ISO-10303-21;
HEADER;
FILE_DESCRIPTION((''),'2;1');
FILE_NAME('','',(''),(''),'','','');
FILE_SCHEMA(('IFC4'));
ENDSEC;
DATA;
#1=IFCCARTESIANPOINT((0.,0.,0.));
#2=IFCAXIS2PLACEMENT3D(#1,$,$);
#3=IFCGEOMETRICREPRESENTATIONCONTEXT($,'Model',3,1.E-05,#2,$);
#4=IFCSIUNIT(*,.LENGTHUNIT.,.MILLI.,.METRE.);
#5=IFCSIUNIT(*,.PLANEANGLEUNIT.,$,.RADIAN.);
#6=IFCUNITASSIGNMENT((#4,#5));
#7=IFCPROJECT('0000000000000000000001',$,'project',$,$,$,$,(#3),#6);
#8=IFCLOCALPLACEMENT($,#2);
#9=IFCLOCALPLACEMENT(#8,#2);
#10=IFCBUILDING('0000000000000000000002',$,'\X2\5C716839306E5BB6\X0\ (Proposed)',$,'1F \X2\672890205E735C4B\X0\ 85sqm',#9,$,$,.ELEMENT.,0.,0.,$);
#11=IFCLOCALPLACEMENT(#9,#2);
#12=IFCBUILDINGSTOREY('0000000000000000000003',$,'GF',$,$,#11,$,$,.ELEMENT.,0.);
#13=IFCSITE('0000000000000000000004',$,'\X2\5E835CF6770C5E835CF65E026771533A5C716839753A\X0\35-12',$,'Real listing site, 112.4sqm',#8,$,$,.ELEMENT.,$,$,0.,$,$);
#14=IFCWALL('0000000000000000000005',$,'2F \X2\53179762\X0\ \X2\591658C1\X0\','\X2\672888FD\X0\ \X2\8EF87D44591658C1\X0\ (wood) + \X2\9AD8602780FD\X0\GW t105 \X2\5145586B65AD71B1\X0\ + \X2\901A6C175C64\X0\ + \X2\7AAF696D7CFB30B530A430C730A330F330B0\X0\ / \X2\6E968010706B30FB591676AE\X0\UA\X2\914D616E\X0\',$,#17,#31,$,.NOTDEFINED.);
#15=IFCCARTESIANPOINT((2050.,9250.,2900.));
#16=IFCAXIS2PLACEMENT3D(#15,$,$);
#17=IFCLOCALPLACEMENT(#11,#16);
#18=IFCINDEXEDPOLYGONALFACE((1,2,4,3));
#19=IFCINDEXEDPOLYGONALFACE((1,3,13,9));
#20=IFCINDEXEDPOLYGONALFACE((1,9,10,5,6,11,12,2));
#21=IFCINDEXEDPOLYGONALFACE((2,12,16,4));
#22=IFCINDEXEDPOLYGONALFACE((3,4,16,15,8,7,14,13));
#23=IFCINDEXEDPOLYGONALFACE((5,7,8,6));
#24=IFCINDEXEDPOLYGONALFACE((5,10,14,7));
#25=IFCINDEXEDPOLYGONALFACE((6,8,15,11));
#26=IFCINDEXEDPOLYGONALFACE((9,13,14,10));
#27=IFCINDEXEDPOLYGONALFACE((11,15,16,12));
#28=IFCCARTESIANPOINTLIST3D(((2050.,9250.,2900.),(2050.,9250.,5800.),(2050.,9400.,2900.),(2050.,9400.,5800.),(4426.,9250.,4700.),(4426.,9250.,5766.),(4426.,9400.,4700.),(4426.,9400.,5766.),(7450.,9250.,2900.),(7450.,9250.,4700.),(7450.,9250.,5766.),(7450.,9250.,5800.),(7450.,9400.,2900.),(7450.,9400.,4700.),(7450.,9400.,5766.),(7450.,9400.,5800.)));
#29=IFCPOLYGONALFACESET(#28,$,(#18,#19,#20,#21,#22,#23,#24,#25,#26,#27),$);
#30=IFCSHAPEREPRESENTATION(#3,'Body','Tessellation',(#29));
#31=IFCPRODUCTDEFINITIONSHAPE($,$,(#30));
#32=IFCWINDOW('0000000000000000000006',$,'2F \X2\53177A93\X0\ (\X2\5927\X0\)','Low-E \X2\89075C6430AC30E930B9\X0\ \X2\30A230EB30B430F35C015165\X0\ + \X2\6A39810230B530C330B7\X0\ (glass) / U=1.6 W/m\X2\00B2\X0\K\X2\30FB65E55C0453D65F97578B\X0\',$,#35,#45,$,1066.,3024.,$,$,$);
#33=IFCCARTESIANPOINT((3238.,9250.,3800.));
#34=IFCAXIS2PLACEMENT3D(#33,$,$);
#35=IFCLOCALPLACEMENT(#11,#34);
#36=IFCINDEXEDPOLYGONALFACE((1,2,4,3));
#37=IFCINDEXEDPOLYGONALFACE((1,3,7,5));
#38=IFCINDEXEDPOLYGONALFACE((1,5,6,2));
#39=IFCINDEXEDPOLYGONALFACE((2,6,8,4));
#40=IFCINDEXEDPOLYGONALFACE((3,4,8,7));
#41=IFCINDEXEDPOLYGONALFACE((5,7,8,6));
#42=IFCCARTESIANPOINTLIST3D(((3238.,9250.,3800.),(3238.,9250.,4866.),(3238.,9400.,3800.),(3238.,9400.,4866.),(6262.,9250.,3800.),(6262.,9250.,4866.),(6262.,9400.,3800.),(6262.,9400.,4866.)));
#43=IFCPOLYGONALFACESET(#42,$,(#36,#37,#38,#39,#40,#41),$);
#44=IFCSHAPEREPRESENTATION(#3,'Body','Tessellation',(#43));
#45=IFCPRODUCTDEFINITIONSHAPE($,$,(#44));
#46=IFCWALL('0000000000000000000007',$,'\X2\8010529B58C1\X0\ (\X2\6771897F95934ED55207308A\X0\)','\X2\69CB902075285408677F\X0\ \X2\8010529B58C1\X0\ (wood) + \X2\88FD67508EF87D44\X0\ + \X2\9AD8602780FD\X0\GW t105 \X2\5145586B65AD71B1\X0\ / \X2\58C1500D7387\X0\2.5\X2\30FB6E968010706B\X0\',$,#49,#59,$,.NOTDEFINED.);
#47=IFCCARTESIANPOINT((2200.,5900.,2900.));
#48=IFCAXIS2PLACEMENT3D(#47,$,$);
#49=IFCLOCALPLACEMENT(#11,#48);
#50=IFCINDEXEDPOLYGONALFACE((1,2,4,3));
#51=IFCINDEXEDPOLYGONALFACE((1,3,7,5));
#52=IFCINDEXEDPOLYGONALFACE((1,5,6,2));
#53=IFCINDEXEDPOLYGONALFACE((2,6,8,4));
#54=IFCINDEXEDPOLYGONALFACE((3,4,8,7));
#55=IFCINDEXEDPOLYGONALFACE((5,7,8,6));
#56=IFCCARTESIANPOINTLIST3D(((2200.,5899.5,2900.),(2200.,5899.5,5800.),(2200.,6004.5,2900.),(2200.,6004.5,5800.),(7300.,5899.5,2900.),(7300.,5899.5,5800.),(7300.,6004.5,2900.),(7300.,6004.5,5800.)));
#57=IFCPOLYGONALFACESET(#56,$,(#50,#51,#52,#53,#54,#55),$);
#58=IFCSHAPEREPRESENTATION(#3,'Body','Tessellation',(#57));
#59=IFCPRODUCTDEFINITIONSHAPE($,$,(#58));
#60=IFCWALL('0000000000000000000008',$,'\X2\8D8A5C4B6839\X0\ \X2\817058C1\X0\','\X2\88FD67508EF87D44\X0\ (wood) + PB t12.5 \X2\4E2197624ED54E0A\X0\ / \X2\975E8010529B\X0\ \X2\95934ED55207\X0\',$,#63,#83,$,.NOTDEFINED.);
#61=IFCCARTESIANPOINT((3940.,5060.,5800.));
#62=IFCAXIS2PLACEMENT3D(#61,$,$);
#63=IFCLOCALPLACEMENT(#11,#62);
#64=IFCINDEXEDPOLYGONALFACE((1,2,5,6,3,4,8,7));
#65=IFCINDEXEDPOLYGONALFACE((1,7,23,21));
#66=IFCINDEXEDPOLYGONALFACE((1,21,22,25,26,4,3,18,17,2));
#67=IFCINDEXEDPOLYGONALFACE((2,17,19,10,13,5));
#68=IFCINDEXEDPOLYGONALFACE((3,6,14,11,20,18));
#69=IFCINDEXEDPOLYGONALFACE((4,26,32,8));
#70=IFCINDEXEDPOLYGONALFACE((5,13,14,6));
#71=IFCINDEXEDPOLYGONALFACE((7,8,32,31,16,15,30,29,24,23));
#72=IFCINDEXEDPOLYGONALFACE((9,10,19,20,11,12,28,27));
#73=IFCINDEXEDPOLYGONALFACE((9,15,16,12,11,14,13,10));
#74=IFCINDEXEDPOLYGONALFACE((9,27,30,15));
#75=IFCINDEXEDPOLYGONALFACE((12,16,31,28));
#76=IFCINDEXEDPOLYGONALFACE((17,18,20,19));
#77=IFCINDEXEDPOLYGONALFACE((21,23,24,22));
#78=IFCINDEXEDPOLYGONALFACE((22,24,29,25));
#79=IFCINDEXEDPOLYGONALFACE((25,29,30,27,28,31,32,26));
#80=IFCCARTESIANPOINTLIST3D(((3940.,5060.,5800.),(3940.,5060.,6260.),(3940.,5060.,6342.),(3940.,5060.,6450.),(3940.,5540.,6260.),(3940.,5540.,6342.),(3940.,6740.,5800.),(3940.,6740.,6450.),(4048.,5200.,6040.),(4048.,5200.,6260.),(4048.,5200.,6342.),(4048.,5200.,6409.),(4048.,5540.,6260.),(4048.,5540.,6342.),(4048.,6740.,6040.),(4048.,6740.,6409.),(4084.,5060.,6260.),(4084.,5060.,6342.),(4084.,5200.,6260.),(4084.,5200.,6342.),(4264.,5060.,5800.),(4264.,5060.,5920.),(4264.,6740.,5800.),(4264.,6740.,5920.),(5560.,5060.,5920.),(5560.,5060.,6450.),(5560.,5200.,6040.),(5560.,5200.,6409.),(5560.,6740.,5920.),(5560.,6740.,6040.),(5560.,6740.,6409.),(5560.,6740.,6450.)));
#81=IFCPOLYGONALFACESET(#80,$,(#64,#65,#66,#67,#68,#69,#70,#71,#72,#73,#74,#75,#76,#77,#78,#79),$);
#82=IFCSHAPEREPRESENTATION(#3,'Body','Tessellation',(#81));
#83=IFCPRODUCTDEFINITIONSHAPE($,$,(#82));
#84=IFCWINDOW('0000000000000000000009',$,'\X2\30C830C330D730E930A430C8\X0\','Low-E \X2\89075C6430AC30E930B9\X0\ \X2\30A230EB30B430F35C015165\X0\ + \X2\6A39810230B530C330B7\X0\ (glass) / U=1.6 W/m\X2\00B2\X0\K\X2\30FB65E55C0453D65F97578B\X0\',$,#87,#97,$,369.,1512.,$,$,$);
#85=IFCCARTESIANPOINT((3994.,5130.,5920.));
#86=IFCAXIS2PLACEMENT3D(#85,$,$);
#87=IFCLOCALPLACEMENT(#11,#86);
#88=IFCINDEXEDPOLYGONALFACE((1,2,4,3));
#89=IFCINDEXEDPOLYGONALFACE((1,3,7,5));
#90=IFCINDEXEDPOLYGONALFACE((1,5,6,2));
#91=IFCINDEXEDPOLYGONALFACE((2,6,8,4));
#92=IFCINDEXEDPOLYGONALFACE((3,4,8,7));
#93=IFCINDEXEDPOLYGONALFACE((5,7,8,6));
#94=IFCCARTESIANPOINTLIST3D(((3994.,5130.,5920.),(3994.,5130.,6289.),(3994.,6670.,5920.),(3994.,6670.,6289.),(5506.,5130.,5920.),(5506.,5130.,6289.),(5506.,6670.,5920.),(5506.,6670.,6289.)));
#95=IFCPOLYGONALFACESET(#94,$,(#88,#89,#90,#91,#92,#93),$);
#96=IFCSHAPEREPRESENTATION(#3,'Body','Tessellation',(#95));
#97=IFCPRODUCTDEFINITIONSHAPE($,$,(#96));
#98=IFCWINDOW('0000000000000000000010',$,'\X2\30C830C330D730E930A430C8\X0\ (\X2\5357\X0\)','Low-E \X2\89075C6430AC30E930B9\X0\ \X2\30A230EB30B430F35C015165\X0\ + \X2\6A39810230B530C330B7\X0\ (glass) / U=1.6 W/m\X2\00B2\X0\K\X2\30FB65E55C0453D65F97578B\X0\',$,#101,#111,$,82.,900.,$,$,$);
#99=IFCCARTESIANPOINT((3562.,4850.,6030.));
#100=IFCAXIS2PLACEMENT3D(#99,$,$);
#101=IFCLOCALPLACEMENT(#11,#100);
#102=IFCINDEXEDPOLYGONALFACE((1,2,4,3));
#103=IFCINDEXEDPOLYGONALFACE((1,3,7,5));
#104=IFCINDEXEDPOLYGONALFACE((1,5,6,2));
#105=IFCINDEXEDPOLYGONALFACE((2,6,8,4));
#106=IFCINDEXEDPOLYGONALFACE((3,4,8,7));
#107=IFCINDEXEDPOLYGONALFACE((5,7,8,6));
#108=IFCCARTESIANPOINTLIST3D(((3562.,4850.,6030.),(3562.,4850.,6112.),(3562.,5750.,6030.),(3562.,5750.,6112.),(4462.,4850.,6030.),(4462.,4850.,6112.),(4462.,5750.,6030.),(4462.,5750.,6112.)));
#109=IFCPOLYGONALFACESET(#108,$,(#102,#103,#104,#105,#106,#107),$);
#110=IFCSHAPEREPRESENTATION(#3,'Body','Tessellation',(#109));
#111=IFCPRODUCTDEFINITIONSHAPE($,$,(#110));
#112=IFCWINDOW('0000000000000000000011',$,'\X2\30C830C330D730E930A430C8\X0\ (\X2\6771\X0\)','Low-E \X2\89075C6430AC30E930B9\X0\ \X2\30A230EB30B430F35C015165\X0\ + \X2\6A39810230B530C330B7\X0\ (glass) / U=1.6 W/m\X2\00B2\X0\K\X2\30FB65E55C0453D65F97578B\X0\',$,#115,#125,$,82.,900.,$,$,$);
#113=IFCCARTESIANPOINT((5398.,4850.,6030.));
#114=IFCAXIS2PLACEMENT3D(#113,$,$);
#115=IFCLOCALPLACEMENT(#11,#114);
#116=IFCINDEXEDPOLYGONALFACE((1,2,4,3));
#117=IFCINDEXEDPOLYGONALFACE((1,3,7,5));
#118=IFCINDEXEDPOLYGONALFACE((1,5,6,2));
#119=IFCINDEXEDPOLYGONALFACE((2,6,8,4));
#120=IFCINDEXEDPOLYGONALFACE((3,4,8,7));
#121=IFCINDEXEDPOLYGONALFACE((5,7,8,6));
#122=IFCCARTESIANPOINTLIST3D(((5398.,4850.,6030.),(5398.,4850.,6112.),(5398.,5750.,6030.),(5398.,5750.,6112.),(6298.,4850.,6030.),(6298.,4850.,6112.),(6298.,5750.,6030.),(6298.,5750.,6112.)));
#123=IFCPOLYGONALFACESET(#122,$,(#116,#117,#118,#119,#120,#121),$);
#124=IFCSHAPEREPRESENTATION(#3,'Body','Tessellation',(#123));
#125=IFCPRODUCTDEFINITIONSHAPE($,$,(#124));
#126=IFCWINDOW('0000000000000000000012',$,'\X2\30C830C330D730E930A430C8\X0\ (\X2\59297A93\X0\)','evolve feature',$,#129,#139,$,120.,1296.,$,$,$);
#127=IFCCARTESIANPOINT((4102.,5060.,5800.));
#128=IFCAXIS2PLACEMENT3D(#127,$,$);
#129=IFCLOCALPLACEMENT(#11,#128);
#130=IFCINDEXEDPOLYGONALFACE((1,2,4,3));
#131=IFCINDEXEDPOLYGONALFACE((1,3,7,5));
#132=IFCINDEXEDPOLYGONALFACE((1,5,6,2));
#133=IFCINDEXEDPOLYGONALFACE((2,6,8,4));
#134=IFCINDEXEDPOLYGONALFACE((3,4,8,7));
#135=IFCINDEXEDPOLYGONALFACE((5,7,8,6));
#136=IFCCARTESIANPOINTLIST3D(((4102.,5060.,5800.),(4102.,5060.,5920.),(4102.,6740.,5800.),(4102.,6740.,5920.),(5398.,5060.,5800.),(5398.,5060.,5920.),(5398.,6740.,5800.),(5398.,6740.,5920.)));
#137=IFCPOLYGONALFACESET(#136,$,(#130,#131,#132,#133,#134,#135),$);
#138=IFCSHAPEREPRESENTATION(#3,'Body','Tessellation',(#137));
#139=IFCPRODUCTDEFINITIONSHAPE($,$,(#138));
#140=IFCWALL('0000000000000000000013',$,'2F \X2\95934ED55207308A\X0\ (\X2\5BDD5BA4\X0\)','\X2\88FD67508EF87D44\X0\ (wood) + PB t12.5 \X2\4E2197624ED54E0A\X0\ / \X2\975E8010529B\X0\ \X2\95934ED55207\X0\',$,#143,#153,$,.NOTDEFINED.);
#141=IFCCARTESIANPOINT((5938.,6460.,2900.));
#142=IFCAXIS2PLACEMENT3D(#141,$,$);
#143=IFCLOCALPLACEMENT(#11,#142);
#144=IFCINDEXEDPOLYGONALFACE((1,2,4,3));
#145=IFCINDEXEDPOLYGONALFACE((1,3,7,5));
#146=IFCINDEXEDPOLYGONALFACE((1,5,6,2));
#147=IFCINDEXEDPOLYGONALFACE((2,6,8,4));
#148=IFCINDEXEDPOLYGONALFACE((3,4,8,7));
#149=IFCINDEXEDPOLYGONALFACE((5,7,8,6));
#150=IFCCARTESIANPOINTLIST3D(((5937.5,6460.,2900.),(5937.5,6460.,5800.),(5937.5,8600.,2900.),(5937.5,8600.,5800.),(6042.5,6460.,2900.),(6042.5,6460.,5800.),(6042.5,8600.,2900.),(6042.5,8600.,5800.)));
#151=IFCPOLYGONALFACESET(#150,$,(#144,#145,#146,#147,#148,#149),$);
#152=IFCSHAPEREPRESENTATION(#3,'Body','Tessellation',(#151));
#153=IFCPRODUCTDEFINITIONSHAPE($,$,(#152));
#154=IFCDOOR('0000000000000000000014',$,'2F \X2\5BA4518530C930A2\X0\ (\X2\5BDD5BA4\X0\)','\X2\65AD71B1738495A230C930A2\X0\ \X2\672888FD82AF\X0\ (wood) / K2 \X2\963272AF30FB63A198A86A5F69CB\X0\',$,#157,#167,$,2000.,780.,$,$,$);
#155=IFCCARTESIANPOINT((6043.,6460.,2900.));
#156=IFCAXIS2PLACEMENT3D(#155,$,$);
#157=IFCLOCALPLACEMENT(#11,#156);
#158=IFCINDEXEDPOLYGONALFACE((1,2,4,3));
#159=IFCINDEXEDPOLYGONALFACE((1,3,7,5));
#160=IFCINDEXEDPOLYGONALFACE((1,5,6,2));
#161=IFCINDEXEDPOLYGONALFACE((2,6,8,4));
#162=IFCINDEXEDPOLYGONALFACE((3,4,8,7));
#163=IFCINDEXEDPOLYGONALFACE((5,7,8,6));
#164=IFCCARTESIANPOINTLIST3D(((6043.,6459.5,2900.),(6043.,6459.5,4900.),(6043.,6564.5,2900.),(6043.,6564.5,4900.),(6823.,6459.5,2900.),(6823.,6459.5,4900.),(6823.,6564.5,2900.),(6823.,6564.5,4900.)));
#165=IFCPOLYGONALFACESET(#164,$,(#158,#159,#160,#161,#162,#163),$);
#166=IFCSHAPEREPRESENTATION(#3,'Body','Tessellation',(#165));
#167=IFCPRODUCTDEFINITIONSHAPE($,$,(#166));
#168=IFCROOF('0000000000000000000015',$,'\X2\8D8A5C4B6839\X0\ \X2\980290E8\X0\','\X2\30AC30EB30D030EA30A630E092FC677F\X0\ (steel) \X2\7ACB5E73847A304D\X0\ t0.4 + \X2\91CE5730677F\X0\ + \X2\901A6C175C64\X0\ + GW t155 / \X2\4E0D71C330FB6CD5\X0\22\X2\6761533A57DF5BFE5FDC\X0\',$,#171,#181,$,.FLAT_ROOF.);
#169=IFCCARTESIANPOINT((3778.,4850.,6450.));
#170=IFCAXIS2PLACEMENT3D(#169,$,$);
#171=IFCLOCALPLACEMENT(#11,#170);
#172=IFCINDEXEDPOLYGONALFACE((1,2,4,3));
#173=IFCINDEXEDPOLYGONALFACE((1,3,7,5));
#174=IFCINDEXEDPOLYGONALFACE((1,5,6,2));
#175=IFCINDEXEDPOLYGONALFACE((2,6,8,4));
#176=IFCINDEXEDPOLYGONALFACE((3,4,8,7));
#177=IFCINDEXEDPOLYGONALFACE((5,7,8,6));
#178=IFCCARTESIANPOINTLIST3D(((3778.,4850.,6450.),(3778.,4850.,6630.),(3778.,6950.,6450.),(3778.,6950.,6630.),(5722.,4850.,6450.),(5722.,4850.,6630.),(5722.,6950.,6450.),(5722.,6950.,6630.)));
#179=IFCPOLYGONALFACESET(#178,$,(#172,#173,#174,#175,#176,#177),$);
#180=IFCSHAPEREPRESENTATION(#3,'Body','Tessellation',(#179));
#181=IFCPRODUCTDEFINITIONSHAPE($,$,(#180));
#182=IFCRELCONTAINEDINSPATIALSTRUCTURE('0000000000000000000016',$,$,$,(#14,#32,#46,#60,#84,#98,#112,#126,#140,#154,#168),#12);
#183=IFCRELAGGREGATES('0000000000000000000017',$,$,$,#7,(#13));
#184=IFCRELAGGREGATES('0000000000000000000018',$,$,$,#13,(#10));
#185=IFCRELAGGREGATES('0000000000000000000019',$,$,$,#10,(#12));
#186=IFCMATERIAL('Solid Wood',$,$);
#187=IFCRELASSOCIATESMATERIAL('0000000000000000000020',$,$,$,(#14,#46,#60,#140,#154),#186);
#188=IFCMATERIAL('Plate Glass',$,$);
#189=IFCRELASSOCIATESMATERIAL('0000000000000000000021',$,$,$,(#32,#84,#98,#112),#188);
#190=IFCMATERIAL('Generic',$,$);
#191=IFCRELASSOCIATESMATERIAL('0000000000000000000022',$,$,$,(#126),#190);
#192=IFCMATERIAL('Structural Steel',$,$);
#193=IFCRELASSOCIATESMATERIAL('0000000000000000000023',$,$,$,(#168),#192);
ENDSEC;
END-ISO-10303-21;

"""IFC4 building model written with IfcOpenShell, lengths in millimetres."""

from ifc_helpers import new_model, si_unit, frame, frame_2d, origin, place, context, project, spatial, rectangle, extrude, material, element, fill, save


model = new_model("IFC4")

# Units and contexts
model_context = context("Model", 3, precision=1e-05, world=origin())
ifc_project = project(units=[si_unit("LENGTHUNIT", "METRE", prefix="MILLI"), si_unit("PLANEANGLEUNIT", "RADIAN")], contexts=[model_context])

# Site, building, storey
site_placement = place(None, origin())
site = spatial("IfcSite", under=ifc_project, at=site_placement, Name="広島県広島市東区山根町35-12", ObjectType="Real listing site, 112.4sqm", CompositionType="ELEMENT", RefElevation=0.0)
building_placement = place(site_placement, origin())
building = spatial("IfcBuilding", under=site, at=building_placement, Name="山根の家 (Proposed)", ObjectType="1F 木造平屋 85sqm", CompositionType="ELEMENT", ElevationOfRefHeight=0.0, ElevationOfTerrain=0.0)
storey_placement = place(building_placement, origin())
storey = spatial("IfcBuildingStorey", under=building, at=storey_placement, Name="GF", CompositionType="ELEMENT", Elevation=0.0)

# Wall, opening, window
ifc_material_1 = material(Name="Solid Wood")
wall_1_placement = place(storey_placement, frame((2050.0, 9250.0, 2900.0)))
wall_1 = element("IfcWall", 1, at=wall_1_placement, inside=storey, material=ifc_material_1, Name="2F 北面 外壁", Description="木製 軸組外壁 (wood) + 高性能GW t105 充填断熱 + 通気層 + 窯業系サイディング / 準耐火・外皮UA配慮", PredefinedType="NOTDEFINED", context=model_context, shape_type="SweptSolid", body=[
    extrude(rectangle(XDim=5400.0, YDim=150.0, at=frame_2d((2700.0, 75.0))), frame((2050.0, 9250.0, 2900.0)), (0.0, 0.0, 1.0), 2900.0),
])
opening_1_placement = place(storey_placement, frame((3238.0, 9250.0, 3800.0)))
opening_1 = element("IfcOpeningElement", 2, at=opening_1_placement, cuts=wall_1, PredefinedType="NOTDEFINED", context=model_context, shape_type="SweptSolid", body=[
    extrude(rectangle(XDim=3024.0, YDim=150.0, at=frame_2d((1512.0, 75.0))), frame((3238.0, 9250.0, 3800.0)), (0.0, 0.0, 1.0), 1066.0),
])
ifc_material_2 = material(Name="Plate Glass")
window_1_placement = place(storey_placement, frame((3238.0, 9250.0, 3800.0)))
window_1 = element("IfcWindow", 3, at=window_1_placement, inside=storey, material=ifc_material_2, Name="2F 北窓 (大)", Description="Low-E 複層ガラス アルゴン封入 + 樹脂サッシ (glass) / U=1.6 W/m²K・日射取得型", OverallHeight=1066.0, OverallWidth=3024.0, context=model_context, shape_type="SweptSolid", body=[
    extrude(rectangle(XDim=3024.0, YDim=150.0, at=frame_2d((1512.0, 75.0))), frame((3238.0, 9250.0, 3800.0)), (0.0, 0.0, 1.0), 1066.0),
])
fill(opening_1, window_1)

# Wall
wall_2_placement = place(storey_placement, frame((2200.0, 5900.0, 2900.0)))
element("IfcWall", 4, at=wall_2_placement, inside=storey, material=ifc_material_1, Name="耐力壁 (東西間仕切り)", Description="構造用合板 耐力壁 (wood) + 製材軸組 + 高性能GW t105 充填断熱 / 壁倍率2.5・準耐火", PredefinedType="NOTDEFINED", context=model_context, shape_type="SweptSolid", body=[
    extrude(rectangle(XDim=5100.0, YDim=105.0, at=frame_2d((2550.0, 52.0))), frame((2200.0, 5900.0, 2900.0)), (0.0, 0.0, 1.0), 2900.0),
])

# Wall, openings, windows
wall_3_placement = place(storey_placement, frame((3940.0, 5060.0, 5800.0)))
wall_3 = element("IfcWall", 5, at=wall_3_placement, inside=storey, material=ifc_material_1, Name="越屋根 腰壁", Description="製材軸組 (wood) + PB t12.5 両面仕上 / 非耐力 間仕切", PredefinedType="NOTDEFINED", context=model_context, shape_type="SweptSolid", body=[
    extrude(rectangle(XDim=1620.0, YDim=1680.0, at=frame_2d((810.0, 840.0))), frame((3940.0, 5060.0, 5800.0)), (0.0, 0.0, 1.0), 650.0),
])
opening_2_placement = place(storey_placement, frame((3994.0, 5130.0, 5920.0)))
opening_2 = element("IfcOpeningElement", 6, at=opening_2_placement, cuts=wall_3, PredefinedType="NOTDEFINED", context=model_context, shape_type="SweptSolid", body=[
    extrude(rectangle(XDim=1512.0, YDim=1540.0, at=frame_2d((756.0, 770.0))), frame((3994.0, 5130.0, 5920.0)), (0.0, 0.0, 1.0), 369.0),
])
opening_3_placement = place(storey_placement, frame((3562.0, 4850.0, 6030.0)))
opening_3 = element("IfcOpeningElement", 7, at=opening_3_placement, cuts=wall_3, PredefinedType="NOTDEFINED", context=model_context, shape_type="SweptSolid", body=[
    extrude(rectangle(XDim=900.0, YDim=900.0, at=frame_2d((450.0, 450.0))), frame((3562.0, 4850.0, 6030.0)), (0.0, 0.0, 1.0), 82.0),
])
opening_4_placement = place(storey_placement, frame((5398.0, 4850.0, 6030.0)))
opening_4 = element("IfcOpeningElement", 8, at=opening_4_placement, cuts=wall_3, PredefinedType="NOTDEFINED", context=model_context, shape_type="SweptSolid", body=[
    extrude(rectangle(XDim=900.0, YDim=900.0, at=frame_2d((450.0, 450.0))), frame((5398.0, 4850.0, 6030.0)), (0.0, 0.0, 1.0), 82.0),
])
opening_5_placement = place(storey_placement, frame((4102.0, 5060.0, 5800.0)))
opening_5 = element("IfcOpeningElement", 9, at=opening_5_placement, cuts=wall_3, PredefinedType="NOTDEFINED", context=model_context, shape_type="SweptSolid", body=[
    extrude(rectangle(XDim=1296.0, YDim=1680.0, at=frame_2d((648.0, 840.0))), frame((4102.0, 5060.0, 5800.0)), (0.0, 0.0, 1.0), 120.0),
])
window_2_placement = place(storey_placement, frame((3994.0, 5130.0, 5920.0)))
window_2 = element("IfcWindow", 10, at=window_2_placement, inside=storey, material=ifc_material_2, Name="トップライト", Description="Low-E 複層ガラス アルゴン封入 + 樹脂サッシ (glass) / U=1.6 W/m²K・日射取得型", OverallHeight=369.0, OverallWidth=1512.0, context=model_context, shape_type="SweptSolid", body=[
    extrude(rectangle(XDim=1512.0, YDim=1540.0, at=frame_2d((756.0, 770.0))), frame((3994.0, 5130.0, 5920.0)), (0.0, 0.0, 1.0), 369.0),
])
fill(opening_2, window_2)
window_3_placement = place(storey_placement, frame((3562.0, 4850.0, 6030.0)))
window_3 = element("IfcWindow", 11, at=window_3_placement, inside=storey, material=ifc_material_2, Name="トップライト (南)", Description="Low-E 複層ガラス アルゴン封入 + 樹脂サッシ (glass) / U=1.6 W/m²K・日射取得型", OverallHeight=82.0, OverallWidth=900.0, context=model_context, shape_type="SweptSolid", body=[
    extrude(rectangle(XDim=900.0, YDim=900.0, at=frame_2d((450.0, 450.0))), frame((3562.0, 4850.0, 6030.0)), (0.0, 0.0, 1.0), 82.0),
])
fill(opening_3, window_3)
window_4_placement = place(storey_placement, frame((5398.0, 4850.0, 6030.0)))
window_4 = element("IfcWindow", 12, at=window_4_placement, inside=storey, material=ifc_material_2, Name="トップライト (東)", Description="Low-E 複層ガラス アルゴン封入 + 樹脂サッシ (glass) / U=1.6 W/m²K・日射取得型", OverallHeight=82.0, OverallWidth=900.0, context=model_context, shape_type="SweptSolid", body=[
    extrude(rectangle(XDim=900.0, YDim=900.0, at=frame_2d((450.0, 450.0))), frame((5398.0, 4850.0, 6030.0)), (0.0, 0.0, 1.0), 82.0),
])
fill(opening_4, window_4)
ifc_material_3 = material(Name="Generic")
window_5_placement = place(storey_placement, frame((4102.0, 5060.0, 5800.0)))
window_5 = element("IfcWindow", 13, at=window_5_placement, inside=storey, material=ifc_material_3, Name="トップライト (天窓)", Description="evolve feature", OverallHeight=120.0, OverallWidth=1296.0, context=model_context, shape_type="SweptSolid", body=[
    extrude(rectangle(XDim=1296.0, YDim=1680.0, at=frame_2d((648.0, 840.0))), frame((4102.0, 5060.0, 5800.0)), (0.0, 0.0, 1.0), 120.0),
])
fill(opening_5, window_5)

# Wall
wall_4_placement = place(storey_placement, frame((5938.0, 6460.0, 2900.0)))
element("IfcWall", 14, at=wall_4_placement, inside=storey, material=ifc_material_1, Name="2F 間仕切り (寝室)", Description="製材軸組 (wood) + PB t12.5 両面仕上 / 非耐力 間仕切", PredefinedType="NOTDEFINED", context=model_context, shape_type="SweptSolid", body=[
    extrude(rectangle(XDim=105.0, YDim=2140.0, at=frame_2d((52.0, 1070.0))), frame((5938.0, 6460.0, 2900.0)), (0.0, 0.0, 1.0), 2900.0),
])

# Door
door_placement = place(storey_placement, frame((6043.0, 6460.0, 2900.0)))
element("IfcDoor", 15, at=door_placement, inside=storey, material=ifc_material_1, Name="2F 室内ドア (寝室)", Description="断熱玄関ドア 木製芯 (wood) / K2 防犯・採風機構", OverallHeight=2000.0, OverallWidth=780.0, context=model_context, shape_type="SweptSolid", body=[
    extrude(rectangle(XDim=780.0, YDim=105.0, at=frame_2d((390.0, 52.0))), frame((6043.0, 6460.0, 2900.0)), (0.0, 0.0, 1.0), 2000.0),
])

# Roof
ifc_material_4 = material(Name="Structural Steel")
roof_placement = place(storey_placement, frame((3778.0, 4850.0, 6450.0)))
element("IfcRoof", 16, at=roof_placement, inside=storey, material=ifc_material_4, Name="越屋根 頂部", Description="ガルバリウム鋼板 (steel) 立平葺き t0.4 + 野地板 + 通気層 + GW t155 / 不燃・法22条区域対応", PredefinedType="FLAT_ROOF", context=model_context, shape_type="SweptSolid", body=[
    extrude(rectangle(XDim=1944.0, YDim=2100.0, at=frame_2d((972.0, 1050.0))), frame((3778.0, 4850.0, 6450.0)), (0.0, 0.0, 1.0), 180.0),
])

save(model, "model.ifc")
